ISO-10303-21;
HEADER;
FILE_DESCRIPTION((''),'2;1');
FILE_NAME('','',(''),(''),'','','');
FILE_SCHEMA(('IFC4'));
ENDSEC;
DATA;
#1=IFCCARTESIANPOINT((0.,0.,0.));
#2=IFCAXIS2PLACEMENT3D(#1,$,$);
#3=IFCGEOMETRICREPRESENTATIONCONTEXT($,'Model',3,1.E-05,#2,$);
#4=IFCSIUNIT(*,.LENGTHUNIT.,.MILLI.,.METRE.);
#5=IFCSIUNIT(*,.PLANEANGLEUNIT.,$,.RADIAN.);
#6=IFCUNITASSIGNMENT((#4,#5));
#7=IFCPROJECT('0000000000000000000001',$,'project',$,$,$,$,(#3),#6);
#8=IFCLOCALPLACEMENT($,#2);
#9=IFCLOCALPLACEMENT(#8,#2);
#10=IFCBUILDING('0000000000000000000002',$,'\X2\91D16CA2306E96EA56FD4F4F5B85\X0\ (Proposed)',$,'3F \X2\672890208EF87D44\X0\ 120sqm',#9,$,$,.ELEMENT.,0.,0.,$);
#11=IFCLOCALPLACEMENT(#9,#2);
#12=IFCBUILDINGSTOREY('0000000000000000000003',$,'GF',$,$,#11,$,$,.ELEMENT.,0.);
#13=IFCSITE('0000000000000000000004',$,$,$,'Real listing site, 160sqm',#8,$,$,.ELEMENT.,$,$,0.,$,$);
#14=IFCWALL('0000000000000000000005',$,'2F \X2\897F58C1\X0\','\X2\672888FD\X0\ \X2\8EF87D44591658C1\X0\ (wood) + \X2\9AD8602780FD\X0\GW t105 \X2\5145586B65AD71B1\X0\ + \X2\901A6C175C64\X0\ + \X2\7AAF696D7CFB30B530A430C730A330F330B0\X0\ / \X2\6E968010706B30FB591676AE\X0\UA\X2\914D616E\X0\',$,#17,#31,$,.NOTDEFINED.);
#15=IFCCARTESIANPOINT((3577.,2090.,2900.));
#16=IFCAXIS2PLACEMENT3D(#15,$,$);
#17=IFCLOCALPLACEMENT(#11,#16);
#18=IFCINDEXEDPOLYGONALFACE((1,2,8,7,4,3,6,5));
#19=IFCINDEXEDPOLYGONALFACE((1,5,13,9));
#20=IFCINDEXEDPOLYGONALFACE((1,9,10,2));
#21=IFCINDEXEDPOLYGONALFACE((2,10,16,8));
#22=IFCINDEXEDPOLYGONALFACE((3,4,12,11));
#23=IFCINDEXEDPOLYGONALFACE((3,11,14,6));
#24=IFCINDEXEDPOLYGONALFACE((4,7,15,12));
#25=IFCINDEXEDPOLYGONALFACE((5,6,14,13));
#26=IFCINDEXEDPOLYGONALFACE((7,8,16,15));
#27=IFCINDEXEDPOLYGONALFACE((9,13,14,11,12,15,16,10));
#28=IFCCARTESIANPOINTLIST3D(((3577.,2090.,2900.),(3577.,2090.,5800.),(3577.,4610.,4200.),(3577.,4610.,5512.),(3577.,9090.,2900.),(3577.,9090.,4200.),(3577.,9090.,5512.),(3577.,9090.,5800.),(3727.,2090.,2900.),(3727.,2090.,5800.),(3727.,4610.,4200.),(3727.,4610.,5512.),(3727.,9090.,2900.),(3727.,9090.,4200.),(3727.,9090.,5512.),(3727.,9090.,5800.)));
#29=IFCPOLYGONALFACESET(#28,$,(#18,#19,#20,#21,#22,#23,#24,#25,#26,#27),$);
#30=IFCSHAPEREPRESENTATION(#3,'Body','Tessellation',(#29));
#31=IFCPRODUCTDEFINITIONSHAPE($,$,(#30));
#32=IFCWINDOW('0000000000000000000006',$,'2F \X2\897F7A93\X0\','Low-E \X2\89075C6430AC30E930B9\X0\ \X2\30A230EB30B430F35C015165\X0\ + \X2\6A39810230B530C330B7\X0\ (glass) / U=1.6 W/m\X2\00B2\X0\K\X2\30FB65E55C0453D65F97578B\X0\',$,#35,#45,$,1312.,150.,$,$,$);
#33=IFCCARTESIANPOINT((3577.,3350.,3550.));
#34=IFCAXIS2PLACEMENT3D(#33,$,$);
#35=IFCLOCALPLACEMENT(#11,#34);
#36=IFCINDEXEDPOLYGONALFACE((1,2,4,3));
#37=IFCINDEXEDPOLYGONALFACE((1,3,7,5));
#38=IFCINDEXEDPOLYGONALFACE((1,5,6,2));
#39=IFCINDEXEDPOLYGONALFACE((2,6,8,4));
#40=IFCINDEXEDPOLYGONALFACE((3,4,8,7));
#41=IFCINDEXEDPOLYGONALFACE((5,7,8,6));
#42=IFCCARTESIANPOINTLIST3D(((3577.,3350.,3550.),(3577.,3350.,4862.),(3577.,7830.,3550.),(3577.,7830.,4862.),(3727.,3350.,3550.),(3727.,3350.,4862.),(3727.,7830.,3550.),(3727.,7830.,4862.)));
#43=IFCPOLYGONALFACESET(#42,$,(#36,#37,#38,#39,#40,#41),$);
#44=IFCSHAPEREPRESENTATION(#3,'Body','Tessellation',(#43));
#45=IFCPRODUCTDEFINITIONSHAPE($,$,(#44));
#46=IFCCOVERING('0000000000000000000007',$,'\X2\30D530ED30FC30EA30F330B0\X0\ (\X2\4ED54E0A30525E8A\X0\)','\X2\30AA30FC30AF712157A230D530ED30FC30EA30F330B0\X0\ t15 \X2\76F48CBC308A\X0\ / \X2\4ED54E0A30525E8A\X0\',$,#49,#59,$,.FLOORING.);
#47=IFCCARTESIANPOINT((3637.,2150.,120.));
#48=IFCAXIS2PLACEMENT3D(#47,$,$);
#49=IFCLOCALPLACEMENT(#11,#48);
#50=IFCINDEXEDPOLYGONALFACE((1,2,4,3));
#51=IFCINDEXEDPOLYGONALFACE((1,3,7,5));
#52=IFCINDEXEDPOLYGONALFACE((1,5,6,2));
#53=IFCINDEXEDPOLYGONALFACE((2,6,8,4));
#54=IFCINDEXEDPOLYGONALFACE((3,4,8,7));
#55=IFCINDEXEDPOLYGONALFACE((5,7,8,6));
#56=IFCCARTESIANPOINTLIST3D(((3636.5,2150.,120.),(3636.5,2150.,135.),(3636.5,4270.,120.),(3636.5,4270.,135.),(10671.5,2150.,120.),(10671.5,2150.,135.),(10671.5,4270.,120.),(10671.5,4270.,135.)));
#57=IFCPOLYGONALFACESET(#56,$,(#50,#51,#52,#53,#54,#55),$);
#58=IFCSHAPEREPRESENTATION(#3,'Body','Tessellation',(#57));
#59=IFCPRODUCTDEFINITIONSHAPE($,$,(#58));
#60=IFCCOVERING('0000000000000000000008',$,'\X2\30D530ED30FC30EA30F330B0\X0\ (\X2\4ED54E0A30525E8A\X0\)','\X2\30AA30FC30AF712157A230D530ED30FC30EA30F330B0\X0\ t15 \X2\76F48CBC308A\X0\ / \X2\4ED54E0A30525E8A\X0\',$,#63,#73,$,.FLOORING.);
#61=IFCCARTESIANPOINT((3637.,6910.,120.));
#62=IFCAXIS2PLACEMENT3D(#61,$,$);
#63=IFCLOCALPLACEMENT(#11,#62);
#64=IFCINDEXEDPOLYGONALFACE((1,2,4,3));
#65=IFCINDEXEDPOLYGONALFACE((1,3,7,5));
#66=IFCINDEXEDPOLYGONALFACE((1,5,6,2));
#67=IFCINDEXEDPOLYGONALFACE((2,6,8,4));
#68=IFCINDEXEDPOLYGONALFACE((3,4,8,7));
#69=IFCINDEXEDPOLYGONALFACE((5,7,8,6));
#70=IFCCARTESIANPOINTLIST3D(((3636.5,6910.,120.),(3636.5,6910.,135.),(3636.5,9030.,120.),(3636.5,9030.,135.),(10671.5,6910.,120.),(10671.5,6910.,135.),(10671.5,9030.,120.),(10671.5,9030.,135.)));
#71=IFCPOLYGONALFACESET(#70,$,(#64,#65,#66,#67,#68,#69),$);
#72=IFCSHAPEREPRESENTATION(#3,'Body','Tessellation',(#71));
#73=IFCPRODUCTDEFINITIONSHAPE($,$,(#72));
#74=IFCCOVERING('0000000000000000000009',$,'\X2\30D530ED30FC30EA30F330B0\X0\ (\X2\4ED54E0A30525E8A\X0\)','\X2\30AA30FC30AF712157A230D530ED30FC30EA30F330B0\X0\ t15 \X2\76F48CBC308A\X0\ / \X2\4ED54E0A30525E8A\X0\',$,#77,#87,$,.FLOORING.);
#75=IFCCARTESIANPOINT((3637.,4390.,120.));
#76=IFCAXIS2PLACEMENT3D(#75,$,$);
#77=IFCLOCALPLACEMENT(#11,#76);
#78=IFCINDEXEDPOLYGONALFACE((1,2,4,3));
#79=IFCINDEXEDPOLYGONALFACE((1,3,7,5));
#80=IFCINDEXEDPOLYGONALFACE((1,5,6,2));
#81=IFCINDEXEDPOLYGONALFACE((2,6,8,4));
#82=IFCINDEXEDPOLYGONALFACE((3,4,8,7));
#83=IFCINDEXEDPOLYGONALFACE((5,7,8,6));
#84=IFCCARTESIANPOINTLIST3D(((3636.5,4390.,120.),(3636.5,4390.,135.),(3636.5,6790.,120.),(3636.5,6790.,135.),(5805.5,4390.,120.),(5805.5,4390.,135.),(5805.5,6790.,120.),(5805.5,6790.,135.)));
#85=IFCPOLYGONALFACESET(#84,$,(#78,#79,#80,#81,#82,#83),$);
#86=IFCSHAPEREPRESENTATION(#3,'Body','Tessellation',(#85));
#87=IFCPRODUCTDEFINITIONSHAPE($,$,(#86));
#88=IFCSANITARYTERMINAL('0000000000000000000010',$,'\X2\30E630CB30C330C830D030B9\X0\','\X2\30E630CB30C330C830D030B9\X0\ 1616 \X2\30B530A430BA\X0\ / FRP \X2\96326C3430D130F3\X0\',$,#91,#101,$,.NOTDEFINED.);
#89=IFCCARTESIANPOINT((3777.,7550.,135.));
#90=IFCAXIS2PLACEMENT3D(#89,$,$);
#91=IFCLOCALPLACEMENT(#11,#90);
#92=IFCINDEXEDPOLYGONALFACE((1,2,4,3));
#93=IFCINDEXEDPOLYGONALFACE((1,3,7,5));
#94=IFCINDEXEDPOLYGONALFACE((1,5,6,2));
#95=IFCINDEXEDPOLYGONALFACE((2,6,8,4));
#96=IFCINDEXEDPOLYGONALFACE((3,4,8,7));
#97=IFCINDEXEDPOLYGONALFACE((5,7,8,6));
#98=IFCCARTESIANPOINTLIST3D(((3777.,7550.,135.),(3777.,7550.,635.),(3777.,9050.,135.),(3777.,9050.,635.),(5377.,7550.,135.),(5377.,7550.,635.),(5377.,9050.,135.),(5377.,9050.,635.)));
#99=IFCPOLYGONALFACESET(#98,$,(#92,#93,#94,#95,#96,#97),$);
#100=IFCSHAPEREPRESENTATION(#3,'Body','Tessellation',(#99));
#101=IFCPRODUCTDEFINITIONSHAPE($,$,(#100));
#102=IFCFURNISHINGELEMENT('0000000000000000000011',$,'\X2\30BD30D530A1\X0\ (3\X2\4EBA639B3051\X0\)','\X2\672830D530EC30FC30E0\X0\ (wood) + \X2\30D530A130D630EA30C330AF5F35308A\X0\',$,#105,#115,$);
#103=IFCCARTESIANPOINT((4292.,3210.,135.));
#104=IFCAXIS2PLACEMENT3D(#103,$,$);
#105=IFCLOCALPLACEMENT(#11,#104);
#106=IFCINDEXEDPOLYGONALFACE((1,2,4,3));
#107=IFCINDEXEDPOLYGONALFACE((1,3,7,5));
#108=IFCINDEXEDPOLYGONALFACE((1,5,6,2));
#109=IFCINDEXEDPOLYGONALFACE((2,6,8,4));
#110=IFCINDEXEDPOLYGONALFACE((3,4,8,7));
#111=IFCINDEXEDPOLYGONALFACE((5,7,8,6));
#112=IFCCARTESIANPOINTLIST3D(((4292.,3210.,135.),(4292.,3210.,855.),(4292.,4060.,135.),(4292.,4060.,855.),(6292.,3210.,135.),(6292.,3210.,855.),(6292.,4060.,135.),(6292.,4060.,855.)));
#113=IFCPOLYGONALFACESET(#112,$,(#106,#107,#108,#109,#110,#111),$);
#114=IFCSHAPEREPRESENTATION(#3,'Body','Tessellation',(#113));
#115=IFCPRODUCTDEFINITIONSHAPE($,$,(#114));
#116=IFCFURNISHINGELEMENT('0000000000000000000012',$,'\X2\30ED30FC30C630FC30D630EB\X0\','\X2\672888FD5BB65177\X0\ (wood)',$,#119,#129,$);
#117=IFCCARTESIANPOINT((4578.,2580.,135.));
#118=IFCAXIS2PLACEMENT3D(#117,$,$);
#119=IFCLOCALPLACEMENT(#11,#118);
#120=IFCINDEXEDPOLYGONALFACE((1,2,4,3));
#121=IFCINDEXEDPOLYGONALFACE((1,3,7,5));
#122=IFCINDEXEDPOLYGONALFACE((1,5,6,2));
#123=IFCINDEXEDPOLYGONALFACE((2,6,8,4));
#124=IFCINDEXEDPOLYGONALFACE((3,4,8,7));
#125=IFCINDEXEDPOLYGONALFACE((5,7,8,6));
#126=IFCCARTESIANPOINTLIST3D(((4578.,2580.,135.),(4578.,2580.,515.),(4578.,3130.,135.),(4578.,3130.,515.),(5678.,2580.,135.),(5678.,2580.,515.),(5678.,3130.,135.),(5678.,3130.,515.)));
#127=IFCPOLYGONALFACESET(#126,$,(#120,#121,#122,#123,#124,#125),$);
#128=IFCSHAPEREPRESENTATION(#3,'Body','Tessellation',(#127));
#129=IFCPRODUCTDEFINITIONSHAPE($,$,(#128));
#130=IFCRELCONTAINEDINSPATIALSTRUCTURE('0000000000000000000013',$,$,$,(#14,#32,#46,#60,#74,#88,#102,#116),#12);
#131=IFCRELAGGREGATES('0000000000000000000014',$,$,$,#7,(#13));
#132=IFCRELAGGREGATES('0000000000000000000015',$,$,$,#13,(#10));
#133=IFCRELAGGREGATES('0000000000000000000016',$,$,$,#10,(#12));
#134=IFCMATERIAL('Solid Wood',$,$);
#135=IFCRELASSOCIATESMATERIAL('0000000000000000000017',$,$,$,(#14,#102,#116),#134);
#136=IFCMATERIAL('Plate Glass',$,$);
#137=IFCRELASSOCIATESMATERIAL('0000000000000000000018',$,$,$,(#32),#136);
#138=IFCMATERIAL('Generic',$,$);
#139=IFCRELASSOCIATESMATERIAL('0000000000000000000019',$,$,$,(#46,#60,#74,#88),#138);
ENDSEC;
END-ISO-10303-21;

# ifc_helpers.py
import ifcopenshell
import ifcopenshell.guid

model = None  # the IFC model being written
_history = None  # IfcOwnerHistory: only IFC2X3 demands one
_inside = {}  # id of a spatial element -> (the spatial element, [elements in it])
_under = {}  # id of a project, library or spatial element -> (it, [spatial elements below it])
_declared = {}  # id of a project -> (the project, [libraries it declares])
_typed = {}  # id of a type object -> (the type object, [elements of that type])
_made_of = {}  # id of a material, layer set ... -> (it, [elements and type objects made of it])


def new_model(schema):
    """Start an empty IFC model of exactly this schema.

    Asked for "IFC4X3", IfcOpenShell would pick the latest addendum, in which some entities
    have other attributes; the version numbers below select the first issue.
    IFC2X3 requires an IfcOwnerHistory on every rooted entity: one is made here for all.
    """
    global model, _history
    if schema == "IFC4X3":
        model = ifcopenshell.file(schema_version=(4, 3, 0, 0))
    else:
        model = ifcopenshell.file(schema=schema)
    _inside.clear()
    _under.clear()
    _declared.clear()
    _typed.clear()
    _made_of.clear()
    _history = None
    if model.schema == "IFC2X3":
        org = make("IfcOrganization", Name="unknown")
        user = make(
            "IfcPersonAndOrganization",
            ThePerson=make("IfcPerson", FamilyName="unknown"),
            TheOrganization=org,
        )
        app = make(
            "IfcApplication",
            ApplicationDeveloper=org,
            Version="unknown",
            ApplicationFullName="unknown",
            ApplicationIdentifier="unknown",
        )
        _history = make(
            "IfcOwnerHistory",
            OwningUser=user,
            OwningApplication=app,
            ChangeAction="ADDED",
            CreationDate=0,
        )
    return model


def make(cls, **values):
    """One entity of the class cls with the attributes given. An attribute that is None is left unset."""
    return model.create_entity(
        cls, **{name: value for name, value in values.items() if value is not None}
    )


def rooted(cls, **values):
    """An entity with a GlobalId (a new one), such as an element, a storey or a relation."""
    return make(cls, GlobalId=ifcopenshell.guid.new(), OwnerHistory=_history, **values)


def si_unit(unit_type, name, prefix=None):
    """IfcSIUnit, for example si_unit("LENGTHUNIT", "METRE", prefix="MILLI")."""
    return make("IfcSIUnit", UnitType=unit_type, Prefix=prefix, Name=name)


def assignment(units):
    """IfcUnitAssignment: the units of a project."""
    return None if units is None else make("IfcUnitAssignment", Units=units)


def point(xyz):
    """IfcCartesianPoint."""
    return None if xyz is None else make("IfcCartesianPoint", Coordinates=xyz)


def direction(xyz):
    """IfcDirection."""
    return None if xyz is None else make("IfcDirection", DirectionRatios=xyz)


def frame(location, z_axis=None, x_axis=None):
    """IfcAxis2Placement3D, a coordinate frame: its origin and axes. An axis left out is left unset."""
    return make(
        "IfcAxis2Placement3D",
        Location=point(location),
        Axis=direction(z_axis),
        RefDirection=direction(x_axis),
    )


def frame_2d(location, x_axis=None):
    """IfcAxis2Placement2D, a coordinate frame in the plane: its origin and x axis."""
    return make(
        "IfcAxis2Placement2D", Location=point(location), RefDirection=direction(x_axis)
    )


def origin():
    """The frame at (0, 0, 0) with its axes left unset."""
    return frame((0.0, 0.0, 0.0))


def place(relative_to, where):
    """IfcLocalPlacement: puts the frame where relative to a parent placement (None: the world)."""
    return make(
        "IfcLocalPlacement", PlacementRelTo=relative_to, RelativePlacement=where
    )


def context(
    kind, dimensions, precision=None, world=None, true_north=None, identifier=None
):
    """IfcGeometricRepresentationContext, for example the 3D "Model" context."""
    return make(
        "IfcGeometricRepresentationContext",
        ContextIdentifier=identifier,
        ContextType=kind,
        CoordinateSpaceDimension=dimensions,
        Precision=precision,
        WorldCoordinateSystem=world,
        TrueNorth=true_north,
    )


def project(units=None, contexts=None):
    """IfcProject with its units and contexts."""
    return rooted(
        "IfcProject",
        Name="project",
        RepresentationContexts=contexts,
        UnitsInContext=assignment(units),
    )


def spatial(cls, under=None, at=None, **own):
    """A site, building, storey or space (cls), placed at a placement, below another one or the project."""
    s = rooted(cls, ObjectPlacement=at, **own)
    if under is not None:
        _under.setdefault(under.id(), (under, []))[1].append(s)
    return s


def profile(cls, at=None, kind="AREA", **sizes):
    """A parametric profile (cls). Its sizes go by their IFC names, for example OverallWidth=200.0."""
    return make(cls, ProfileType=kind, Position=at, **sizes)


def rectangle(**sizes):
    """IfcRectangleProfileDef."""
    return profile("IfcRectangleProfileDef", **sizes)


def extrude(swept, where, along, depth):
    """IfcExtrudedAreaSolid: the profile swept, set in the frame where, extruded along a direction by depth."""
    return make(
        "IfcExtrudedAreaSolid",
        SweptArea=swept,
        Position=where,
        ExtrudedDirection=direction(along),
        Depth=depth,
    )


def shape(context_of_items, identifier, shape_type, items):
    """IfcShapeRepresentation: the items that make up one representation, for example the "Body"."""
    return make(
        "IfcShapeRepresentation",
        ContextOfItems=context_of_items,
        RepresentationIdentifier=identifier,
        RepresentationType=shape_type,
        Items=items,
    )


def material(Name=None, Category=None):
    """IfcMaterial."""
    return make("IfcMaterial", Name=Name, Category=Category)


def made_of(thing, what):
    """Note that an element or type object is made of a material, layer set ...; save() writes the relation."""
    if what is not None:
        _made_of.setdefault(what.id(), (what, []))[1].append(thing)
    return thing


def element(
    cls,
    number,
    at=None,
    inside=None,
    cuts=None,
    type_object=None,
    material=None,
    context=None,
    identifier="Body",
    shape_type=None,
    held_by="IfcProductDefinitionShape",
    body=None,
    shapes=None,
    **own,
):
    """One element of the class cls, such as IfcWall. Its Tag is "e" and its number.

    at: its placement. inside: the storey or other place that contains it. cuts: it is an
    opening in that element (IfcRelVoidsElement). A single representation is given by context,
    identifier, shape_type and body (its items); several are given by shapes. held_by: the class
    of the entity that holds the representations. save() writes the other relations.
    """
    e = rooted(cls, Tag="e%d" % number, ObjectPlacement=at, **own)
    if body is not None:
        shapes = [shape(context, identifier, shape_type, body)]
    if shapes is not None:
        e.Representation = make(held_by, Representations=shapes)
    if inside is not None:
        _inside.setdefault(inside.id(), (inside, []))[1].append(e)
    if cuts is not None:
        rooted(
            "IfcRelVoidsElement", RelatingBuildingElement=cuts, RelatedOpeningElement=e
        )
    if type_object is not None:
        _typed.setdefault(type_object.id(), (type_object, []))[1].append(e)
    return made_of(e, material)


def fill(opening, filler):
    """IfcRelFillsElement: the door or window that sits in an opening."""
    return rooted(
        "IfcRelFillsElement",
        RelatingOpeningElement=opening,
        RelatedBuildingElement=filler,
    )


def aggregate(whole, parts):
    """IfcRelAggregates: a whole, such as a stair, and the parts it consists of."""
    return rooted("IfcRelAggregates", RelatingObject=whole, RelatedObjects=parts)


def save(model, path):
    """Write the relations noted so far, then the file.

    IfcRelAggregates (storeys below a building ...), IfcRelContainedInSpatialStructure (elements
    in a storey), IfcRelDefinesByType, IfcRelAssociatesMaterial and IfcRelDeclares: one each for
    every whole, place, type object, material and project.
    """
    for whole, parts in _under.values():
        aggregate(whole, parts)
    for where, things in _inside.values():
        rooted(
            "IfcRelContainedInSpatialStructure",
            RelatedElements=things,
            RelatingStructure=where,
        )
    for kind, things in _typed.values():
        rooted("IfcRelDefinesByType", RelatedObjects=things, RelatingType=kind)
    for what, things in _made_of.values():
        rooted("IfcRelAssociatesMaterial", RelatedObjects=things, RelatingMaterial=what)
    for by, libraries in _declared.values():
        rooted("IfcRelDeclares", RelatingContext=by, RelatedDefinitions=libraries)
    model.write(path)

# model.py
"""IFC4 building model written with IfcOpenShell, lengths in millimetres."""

from ifc_helpers import new_model, si_unit, frame, frame_2d, origin, place, context, project, spatial, rectangle, extrude, material, element, fill, save


model = new_model("IFC4")

# Units and contexts
model_context = context("Model", 3, precision=1e-05, world=origin())
ifc_project = project(units=[si_unit("LENGTHUNIT", "METRE", prefix="MILLI"), si_unit("PLANEANGLEUNIT", "RADIAN")], contexts=[model_context])

# Site, building, storey
site_placement = place(None, origin())
site = spatial("IfcSite", under=ifc_project, at=site_placement, ObjectType="Real listing site, 160sqm", CompositionType="ELEMENT", RefElevation=0.0)
building_placement = place(site_placement, origin())
building = spatial("IfcBuilding", under=site, at=building_placement, Name="金沢の雪国住宅 (Proposed)", ObjectType="3F 木造軸組 120sqm", CompositionType="ELEMENT", ElevationOfRefHeight=0.0, ElevationOfTerrain=0.0)
storey_placement = place(building_placement, origin())
storey = spatial("IfcBuildingStorey", under=building, at=storey_placement, Name="GF", CompositionType="ELEMENT", Elevation=0.0)

# Shared definitions
ifc_material_1 = material(Name="Solid Wood")

# Shared definitions
ifc_material_2 = material(Name="Plate Glass")

# Wall, opening, window
wall_1_placement = place(storey_placement, frame((3577.0, 2090.0, 2900.0)))
wall_1 = element("IfcWall", 1, at=wall_1_placement, inside=storey, material=ifc_material_1, Name="2F 西壁", Description="木製 軸組外壁 (wood) + 高性能GW t105 充填断熱 + 通気層 + 窯業系サイディング / 準耐火・外皮UA配慮", PredefinedType="NOTDEFINED", context=model_context, shape_type="SweptSolid", body=[
    extrude(rectangle(XDim=150.0, YDim=7000.0, at=frame_2d((75.0, 3500.0))), frame((3577.0, 2090.0, 2900.0)), (0.0, 0.0, 1.0), 2900.0),
])
opening_1_placement = place(storey_placement, frame((3577.0, 3350.0, 3550.0)))
opening_1 = element("IfcOpeningElement", 2, at=opening_1_placement, cuts=wall_1, PredefinedType="NOTDEFINED", context=model_context, shape_type="SweptSolid", body=[
    extrude(rectangle(XDim=150.0, YDim=4480.0, at=frame_2d((75.0, 2240.0))), frame((3577.0, 3350.0, 3550.0)), (0.0, 0.0, 1.0), 1312.0),
])
window_1_placement = place(storey_placement, frame((3577.0, 3350.0, 3550.0)))
window_1 = element("IfcWindow", 3, at=window_1_placement, inside=storey, material=ifc_material_2, Name="2F 西窓", Description="Low-E 複層ガラス アルゴン封入 + 樹脂サッシ (glass) / U=1.6 W/m²K・日射取得型", OverallHeight=1312.0, OverallWidth=150.0, context=model_context, shape_type="SweptSolid", body=[
    extrude(rectangle(XDim=150.0, YDim=4480.0, at=frame_2d((75.0, 2240.0))), frame((3577.0, 3350.0, 3550.0)), (0.0, 0.0, 1.0), 1312.0),
])
fill(opening_1, window_1)

# Coverings
ifc_material_3 = material(Name="Generic")
covering_1_placement = place(storey_placement, frame((3637.0, 2150.0, 120.0)))
element("IfcCovering", 4, at=covering_1_placement, inside=storey, material=ifc_material_3, Name="フローリング (仕上げ床)", Description="オーク無垢フローリング t15 直貼り / 仕上げ床", PredefinedType="FLOORING", context=model_context, shape_type="SweptSolid", body=[
    extrude(rectangle(XDim=7035.0, YDim=2120.0, at=frame_2d((3517.0, 1060.0))), frame((3637.0, 2150.0, 120.0)), (0.0, 0.0, 1.0), 15.0),
])
covering_2_placement = place(storey_placement, frame((3637.0, 6910.0, 120.0)))
element("IfcCovering", 5, at=covering_2_placement, inside=storey, material=ifc_material_3, Name="フローリング (仕上げ床)", Description="オーク無垢フローリング t15 直貼り / 仕上げ床", PredefinedType="FLOORING", context=model_context, shape_type="SweptSolid", body=[
    extrude(rectangle(XDim=7035.0, YDim=2120.0, at=frame_2d((3517.0, 1060.0))), frame((3637.0, 6910.0, 120.0)), (0.0, 0.0, 1.0), 15.0),
])
covering_3_placement = place(storey_placement, frame((3637.0, 4390.0, 120.0)))
element("IfcCovering", 6, at=covering_3_placement, inside=storey, material=ifc_material_3, Name="フローリング (仕上げ床)", Description="オーク無垢フローリング t15 直貼り / 仕上げ床", PredefinedType="FLOORING", context=model_context, shape_type="SweptSolid", body=[
    extrude(rectangle(XDim=2169.0, YDim=2400.0, at=frame_2d((1084.0, 1200.0))), frame((3637.0, 4390.0, 120.0)), (0.0, 0.0, 1.0), 15.0),
])

# Sanitary terminal
sanitary_terminal_placement = place(storey_placement, frame((3777.0, 7550.0, 135.0)))
element("IfcSanitaryTerminal", 7, at=sanitary_terminal_placement, inside=storey, material=ifc_material_3, Name="ユニットバス", Description="ユニットバス 1616 サイズ / FRP 防水パン", PredefinedType="NOTDEFINED", context=model_context, shape_type="SweptSolid", body=[
    extrude(rectangle(XDim=1600.0, YDim=1500.0, at=frame_2d((800.0, 750.0))), frame((3777.0, 7550.0, 135.0)), (0.0, 0.0, 1.0), 500.0),
])

# Furnishing elements
furnishing_1_placement = place(storey_placement, frame((4292.0, 3210.0, 135.0)))
element("IfcFurnishingElement", 8, at=furnishing_1_placement, inside=storey, material=ifc_material_1, Name="ソファ (3人掛け)", Description="木フレーム (wood) + ファブリック張り", context=model_context, shape_type="SweptSolid", body=[
    extrude(rectangle(XDim=2000.0, YDim=850.0, at=frame_2d((1000.0, 425.0))), frame((4292.0, 3210.0, 135.0)), (0.0, 0.0, 1.0), 720.0),
])
furnishing_2_placement = place(storey_placement, frame((4578.0, 2580.0, 135.0)))
element("IfcFurnishingElement", 9, at=furnishing_2_placement, inside=storey, material=ifc_material_1, Name="ローテーブル", Description="木製家具 (wood)", context=model_context, shape_type="SweptSolid", body=[
    extrude(rectangle(XDim=1100.0, YDim=550.0, at=frame_2d((550.0, 275.0))), frame((4578.0, 2580.0, 135.0)), (0.0, 0.0, 1.0), 380.0),
])

save(model, "model.ifc")
